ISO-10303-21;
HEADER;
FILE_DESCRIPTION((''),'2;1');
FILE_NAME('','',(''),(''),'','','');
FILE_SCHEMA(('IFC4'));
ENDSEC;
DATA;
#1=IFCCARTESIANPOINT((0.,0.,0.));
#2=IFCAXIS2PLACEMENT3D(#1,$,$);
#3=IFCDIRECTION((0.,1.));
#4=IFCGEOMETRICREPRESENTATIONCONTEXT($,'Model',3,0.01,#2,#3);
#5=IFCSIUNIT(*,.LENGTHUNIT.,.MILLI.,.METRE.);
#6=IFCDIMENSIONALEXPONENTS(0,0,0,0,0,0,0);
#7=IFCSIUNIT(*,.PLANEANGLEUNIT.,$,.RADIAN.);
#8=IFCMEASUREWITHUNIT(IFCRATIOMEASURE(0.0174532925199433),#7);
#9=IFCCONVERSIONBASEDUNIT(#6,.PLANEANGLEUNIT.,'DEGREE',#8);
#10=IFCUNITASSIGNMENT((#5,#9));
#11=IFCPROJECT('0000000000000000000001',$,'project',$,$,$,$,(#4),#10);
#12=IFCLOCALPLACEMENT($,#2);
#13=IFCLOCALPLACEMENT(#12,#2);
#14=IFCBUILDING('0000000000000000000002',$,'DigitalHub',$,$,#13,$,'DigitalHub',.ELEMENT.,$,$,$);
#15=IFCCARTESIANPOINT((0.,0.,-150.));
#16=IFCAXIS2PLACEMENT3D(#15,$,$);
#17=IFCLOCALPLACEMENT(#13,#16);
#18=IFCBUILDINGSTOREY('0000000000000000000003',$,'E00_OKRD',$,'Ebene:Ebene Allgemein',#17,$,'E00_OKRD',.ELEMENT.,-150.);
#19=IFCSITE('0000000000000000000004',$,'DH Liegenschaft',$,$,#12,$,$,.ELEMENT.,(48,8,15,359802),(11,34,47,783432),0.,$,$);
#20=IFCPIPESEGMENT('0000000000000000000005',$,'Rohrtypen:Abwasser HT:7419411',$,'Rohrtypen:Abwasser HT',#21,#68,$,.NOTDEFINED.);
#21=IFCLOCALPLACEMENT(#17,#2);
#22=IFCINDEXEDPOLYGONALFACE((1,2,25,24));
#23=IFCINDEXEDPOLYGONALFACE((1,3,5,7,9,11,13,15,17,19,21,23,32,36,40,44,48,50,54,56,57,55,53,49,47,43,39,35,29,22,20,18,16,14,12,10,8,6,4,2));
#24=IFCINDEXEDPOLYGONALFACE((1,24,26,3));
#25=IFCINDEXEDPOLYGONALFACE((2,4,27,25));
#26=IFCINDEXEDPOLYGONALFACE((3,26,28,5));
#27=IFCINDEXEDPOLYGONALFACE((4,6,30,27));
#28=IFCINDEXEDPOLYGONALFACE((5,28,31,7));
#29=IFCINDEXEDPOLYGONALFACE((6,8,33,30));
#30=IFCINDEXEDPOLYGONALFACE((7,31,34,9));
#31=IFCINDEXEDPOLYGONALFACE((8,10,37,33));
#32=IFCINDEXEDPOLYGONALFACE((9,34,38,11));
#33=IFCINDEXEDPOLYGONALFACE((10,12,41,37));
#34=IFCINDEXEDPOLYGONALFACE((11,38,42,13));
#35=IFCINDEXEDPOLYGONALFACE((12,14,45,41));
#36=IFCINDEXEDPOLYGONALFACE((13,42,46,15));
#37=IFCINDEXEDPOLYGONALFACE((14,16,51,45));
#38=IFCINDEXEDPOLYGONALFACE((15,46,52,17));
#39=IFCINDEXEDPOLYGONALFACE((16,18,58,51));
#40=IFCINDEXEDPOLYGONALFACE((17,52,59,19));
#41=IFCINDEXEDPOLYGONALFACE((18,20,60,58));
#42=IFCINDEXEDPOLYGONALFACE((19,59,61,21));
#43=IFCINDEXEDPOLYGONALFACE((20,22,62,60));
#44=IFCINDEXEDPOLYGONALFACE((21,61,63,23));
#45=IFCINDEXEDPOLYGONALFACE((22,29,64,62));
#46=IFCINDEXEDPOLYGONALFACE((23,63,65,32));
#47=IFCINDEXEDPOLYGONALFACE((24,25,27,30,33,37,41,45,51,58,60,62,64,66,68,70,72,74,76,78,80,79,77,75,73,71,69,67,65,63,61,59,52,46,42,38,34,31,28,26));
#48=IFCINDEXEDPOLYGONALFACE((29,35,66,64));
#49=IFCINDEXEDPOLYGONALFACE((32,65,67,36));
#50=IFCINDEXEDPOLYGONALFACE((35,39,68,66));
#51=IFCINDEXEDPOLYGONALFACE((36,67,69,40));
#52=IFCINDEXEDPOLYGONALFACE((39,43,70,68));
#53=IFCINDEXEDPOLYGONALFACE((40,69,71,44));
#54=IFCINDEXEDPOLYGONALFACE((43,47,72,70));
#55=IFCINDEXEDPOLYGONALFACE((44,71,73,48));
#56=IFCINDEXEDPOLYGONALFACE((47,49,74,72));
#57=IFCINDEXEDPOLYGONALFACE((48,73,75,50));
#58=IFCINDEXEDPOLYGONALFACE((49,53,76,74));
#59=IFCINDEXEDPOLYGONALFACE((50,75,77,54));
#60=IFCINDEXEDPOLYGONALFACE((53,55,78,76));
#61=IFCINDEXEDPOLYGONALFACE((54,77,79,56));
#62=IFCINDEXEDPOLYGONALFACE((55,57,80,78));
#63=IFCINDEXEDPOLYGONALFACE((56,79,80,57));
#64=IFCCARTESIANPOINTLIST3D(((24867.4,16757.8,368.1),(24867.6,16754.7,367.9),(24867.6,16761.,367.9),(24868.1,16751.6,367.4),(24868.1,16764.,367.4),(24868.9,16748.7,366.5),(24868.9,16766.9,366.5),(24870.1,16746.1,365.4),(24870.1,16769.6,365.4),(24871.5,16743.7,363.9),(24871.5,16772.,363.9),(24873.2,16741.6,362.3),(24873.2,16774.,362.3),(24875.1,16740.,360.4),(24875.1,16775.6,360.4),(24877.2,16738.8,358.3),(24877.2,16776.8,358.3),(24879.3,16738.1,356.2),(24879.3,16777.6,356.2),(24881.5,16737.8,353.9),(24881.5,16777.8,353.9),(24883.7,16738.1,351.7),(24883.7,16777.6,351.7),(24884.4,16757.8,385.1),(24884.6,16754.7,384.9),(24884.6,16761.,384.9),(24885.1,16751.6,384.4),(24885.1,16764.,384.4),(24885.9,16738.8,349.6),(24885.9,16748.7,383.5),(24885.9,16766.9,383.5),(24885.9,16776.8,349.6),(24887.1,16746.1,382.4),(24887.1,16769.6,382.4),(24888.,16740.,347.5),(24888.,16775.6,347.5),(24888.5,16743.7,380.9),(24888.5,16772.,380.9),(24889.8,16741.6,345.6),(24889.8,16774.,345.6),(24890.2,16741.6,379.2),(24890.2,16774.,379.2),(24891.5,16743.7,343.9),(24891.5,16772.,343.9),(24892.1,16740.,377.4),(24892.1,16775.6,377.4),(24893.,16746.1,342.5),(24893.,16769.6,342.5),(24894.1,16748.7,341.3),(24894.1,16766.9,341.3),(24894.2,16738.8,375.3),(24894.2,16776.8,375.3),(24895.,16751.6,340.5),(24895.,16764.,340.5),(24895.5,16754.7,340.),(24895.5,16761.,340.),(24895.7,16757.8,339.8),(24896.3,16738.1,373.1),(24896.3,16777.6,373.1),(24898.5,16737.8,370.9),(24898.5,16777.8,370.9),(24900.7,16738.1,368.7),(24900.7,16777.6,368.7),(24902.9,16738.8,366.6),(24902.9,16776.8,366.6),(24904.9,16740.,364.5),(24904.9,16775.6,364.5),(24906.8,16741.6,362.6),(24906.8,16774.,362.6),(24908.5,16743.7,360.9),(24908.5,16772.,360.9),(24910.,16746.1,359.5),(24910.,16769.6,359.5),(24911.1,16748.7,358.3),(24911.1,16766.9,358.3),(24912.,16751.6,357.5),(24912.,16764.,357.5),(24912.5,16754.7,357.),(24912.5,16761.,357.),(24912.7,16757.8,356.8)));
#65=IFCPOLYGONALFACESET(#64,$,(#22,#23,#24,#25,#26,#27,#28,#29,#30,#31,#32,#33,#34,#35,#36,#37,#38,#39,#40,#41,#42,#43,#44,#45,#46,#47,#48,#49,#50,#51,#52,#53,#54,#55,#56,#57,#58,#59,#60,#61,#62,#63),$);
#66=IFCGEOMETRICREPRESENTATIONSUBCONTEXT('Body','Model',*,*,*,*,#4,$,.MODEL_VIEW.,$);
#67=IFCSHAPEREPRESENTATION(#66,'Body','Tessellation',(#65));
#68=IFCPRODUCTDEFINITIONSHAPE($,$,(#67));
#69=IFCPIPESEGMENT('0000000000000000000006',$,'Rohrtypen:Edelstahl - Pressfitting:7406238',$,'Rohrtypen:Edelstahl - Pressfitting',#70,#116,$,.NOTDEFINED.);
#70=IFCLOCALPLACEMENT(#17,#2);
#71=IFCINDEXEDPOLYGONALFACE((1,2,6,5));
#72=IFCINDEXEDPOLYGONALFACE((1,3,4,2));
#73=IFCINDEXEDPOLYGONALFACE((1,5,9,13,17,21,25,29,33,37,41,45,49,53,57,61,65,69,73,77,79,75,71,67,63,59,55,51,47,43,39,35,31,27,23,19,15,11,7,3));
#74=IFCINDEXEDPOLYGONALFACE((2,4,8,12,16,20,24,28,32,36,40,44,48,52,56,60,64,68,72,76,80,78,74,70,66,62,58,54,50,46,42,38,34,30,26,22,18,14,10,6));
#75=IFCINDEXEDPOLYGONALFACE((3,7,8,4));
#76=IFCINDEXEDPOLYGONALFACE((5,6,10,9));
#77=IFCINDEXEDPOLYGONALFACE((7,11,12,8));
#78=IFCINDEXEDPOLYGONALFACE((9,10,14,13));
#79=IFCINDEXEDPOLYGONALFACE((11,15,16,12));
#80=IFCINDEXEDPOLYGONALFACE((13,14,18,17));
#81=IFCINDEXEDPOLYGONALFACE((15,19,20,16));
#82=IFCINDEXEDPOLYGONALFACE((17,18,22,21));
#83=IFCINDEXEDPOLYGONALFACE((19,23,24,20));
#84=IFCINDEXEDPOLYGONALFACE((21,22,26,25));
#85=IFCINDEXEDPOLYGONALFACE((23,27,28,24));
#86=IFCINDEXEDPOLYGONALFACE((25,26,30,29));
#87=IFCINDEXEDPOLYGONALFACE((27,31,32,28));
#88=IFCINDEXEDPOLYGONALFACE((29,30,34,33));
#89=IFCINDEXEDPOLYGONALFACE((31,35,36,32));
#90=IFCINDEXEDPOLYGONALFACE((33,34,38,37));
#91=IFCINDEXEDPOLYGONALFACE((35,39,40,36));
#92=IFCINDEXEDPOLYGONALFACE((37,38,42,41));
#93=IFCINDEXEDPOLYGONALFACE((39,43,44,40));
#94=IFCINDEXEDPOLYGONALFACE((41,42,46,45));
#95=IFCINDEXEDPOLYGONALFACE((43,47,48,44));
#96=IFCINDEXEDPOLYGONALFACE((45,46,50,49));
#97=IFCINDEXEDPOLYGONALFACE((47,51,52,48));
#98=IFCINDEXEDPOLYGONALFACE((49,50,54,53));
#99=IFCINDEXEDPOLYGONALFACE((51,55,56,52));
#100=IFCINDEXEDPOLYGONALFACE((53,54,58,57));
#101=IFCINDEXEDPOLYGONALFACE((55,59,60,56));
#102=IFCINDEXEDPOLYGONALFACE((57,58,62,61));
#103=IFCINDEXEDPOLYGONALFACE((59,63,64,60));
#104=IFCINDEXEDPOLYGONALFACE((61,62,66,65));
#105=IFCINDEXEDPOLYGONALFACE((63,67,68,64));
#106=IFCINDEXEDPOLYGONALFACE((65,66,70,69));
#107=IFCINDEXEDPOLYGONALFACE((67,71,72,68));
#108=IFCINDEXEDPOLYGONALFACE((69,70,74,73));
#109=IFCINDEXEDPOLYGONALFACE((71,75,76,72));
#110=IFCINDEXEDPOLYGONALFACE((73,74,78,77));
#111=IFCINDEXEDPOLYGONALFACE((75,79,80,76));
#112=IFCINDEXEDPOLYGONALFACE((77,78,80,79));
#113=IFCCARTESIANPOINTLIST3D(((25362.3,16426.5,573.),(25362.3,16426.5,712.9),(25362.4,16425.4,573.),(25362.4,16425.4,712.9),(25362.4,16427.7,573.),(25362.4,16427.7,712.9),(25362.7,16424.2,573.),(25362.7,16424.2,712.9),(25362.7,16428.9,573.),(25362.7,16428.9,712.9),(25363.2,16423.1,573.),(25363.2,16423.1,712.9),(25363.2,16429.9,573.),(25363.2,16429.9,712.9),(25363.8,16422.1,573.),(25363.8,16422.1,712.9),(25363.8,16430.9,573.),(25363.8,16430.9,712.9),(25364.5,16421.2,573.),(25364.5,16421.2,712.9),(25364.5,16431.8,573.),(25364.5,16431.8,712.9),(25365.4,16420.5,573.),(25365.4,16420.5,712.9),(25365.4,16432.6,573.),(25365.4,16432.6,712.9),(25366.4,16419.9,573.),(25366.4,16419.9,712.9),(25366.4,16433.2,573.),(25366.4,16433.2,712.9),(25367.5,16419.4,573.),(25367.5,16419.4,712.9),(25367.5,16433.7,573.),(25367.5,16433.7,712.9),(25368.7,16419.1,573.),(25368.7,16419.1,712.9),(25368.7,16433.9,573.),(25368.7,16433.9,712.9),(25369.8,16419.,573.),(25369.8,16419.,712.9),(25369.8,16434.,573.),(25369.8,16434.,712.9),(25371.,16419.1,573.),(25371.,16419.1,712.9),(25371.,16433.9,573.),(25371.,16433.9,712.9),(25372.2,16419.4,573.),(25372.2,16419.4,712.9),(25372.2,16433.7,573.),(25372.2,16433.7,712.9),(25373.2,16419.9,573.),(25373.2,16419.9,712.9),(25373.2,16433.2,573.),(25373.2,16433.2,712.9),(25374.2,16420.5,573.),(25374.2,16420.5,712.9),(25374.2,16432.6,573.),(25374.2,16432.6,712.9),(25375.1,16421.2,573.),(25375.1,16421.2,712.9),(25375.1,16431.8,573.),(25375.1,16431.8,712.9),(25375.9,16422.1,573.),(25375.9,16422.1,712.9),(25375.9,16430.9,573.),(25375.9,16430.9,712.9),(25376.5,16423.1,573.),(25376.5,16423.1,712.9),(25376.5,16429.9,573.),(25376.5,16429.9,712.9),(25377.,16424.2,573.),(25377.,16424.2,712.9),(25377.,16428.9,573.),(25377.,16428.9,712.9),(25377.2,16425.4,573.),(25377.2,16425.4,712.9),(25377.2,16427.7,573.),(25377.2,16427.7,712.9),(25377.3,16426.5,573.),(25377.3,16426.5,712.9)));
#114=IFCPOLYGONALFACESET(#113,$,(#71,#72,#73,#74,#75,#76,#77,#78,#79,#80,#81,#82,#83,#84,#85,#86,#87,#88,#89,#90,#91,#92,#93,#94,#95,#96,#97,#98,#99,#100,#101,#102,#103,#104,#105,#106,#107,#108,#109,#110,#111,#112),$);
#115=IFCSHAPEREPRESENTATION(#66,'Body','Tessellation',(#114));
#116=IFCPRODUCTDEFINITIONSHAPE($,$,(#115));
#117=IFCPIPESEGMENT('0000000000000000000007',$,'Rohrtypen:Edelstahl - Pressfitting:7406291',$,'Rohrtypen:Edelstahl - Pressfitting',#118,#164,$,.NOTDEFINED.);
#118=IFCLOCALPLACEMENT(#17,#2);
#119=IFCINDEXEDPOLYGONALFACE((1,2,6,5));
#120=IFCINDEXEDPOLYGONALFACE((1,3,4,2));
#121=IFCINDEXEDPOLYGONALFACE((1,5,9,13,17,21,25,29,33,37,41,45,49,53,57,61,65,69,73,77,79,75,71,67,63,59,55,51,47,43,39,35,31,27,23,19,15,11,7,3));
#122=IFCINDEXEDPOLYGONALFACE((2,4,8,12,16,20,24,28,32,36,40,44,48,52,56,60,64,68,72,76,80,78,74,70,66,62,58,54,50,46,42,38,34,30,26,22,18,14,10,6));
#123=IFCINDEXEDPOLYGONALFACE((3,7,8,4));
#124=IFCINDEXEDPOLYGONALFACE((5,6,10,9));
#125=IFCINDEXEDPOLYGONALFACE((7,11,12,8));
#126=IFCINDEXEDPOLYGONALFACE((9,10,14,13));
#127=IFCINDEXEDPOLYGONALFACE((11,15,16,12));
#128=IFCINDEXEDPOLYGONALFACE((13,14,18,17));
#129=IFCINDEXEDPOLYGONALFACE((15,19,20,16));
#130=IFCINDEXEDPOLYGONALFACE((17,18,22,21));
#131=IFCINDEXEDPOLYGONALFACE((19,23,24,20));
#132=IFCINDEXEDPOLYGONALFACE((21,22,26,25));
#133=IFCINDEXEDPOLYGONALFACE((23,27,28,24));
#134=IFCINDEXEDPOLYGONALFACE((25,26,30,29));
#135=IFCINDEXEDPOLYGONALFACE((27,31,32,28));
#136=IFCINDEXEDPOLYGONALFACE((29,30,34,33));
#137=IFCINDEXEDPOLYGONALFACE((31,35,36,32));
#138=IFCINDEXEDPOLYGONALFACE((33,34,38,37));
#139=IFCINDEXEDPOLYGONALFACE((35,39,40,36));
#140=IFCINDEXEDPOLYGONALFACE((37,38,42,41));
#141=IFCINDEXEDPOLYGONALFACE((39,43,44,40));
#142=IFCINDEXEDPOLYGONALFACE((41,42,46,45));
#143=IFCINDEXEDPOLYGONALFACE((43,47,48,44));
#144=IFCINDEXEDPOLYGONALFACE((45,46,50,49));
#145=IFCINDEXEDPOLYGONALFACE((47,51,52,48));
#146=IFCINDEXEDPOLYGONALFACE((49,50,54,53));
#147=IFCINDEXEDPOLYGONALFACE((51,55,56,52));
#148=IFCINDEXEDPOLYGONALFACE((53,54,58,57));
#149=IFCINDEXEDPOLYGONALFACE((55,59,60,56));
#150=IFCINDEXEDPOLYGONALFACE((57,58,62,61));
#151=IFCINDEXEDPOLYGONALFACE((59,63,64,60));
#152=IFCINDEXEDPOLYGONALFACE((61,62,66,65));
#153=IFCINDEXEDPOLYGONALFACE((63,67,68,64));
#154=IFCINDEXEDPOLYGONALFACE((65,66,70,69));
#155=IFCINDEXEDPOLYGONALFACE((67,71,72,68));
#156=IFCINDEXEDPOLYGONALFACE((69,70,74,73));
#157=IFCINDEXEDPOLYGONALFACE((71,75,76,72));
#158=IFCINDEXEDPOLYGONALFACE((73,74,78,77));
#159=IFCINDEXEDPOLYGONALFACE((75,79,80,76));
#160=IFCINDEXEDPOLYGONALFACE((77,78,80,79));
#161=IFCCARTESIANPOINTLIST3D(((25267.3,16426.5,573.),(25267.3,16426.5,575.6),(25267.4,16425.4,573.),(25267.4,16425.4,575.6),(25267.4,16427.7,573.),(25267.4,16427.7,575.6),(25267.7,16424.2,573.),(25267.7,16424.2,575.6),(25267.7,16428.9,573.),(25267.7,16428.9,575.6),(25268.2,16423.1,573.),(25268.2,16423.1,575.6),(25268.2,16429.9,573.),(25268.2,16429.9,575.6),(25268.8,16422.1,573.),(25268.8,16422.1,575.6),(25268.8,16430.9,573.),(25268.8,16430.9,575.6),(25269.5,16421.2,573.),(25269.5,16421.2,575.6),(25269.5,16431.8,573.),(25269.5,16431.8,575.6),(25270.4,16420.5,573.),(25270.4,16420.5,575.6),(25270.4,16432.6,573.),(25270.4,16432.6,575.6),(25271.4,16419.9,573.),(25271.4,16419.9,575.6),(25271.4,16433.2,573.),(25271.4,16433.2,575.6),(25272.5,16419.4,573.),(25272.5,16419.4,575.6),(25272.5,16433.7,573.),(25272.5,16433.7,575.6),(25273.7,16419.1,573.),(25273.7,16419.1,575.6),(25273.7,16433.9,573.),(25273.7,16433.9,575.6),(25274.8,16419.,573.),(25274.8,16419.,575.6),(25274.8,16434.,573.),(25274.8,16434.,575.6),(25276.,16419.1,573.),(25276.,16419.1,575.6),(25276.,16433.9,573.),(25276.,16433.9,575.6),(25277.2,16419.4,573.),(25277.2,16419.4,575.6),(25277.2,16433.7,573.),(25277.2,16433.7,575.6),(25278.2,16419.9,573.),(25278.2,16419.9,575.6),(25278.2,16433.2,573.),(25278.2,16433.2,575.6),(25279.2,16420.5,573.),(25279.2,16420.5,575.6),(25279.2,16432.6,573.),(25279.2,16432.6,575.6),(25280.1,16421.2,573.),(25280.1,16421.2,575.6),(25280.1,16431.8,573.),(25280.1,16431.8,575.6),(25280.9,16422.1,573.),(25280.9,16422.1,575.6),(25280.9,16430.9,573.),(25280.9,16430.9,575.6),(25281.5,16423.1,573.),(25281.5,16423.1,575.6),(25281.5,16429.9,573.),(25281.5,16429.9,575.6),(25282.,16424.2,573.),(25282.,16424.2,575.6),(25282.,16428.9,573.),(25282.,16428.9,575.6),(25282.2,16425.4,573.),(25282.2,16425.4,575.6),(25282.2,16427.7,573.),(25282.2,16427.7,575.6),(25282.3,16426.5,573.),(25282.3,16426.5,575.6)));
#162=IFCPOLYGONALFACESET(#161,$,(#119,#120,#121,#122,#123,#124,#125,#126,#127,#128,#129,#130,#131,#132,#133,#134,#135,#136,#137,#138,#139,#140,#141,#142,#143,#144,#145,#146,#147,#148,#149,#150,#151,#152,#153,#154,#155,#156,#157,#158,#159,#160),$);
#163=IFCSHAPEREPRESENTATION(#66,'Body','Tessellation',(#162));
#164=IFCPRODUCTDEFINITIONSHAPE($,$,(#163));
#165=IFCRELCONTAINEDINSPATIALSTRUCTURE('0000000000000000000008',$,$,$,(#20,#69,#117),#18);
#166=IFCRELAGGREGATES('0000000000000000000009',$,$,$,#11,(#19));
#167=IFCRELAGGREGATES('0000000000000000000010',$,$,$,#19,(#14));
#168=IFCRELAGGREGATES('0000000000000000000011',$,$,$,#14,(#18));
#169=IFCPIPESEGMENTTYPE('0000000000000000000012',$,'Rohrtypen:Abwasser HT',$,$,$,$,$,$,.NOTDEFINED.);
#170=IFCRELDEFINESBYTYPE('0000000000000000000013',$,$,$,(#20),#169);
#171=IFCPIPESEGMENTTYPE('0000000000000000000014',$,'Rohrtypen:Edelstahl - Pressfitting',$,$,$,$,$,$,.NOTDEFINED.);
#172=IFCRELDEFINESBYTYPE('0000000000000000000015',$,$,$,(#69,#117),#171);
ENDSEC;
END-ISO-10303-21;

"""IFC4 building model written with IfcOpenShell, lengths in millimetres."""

from ifc_helpers import new_model, entity, si_unit, converted_unit, direction, frame, origin, place, context, subcontext, project, spatial, indexed_curve, outline, extrude, type_object, element, save


model = new_model("IFC4")

# Units and contexts
model_context = context("Model", 3, precision=0.01, world=origin(), true_north=direction((0.0, 1.0)))
body_context = subcontext(model_context, "Body", "Model", "MODEL_VIEW")
ifc_project = project(units=[si_unit("LENGTHUNIT", "METRE", prefix="MILLI"), converted_unit("PLANEANGLEUNIT", "DEGREE", entity("IfcRatioMeasure", 0.0174532925199433), si_unit("PLANEANGLEUNIT", "RADIAN"), dimensions=[0, 0, 0, 0, 0, 0, 0])], contexts=[model_context])

# Site, building, storey
site_placement = place(None, origin())
site = spatial("IfcSite", under=ifc_project, at=site_placement, Name="DH Liegenschaft", CompositionType="ELEMENT", RefLatitude=(48, 8, 15, 359802), RefLongitude=(11, 34, 47, 783432), RefElevation=0.0)
building_placement = place(site_placement, origin())
building = spatial("IfcBuilding", under=site, at=building_placement, Name="DigitalHub", LongName="DigitalHub", CompositionType="ELEMENT")
storey_placement = place(building_placement, frame((0.0, 0.0, -150.0)))
storey = spatial("IfcBuildingStorey", under=building, at=storey_placement, Name="E00_OKRD", ObjectType="Ebene:Ebene Allgemein", LongName="E00_OKRD", CompositionType="ELEMENT", Elevation=-150.0)

# Pipe segments
pipe_segment_type_1 = type_object("IfcPipeSegmentType", Name="Rohrtypen:Abwasser HT", PredefinedType="NOTDEFINED")
pipe_segment_1_placement = place(storey_placement, frame((24865.8, 16736.2, 338.2)))
element("IfcPipeSegment", 1, at=pipe_segment_1_placement, inside=storey, type_object=pipe_segment_type_1, Name="Rohrtypen:Abwasser HT:7419411", ObjectType="Rohrtypen:Abwasser HT", PredefinedType="NOTDEFINED", context=body_context, shape_type="SweptSolid", body=[
    extrude(outline(indexed_curve([(20.0, 0.0), (19.8, 3.1), (19.0, 6.2), (17.8, 9.1), (16.2, 11.8), (14.1, 14.1), (11.8, 16.2), (9.1, 17.8), (6.2, 19.0), (3.1, 19.8), (0.0, 20.0), (-3.1, 19.8), (-6.2, 19.0), (-9.1, 17.8), (-11.8, 16.2), (-14.1, 14.1), (-16.2, 11.8), (-17.8, 9.1), (-19.0, 6.2), (-19.8, 3.1), (-20.0, 0.0), (-19.8, -3.1), (-19.0, -6.2), (-17.8, -9.1), (-16.2, -11.8), (-14.1, -14.1), (-11.8, -16.2), (-9.1, -17.8), (-6.2, -19.0), (-3.1, -19.8), (0.0, -20.0), (3.1, -19.8), (6.2, -19.0), (9.1, -17.8), (11.8, -16.2), (14.1, -14.1), (16.2, -11.8), (17.8, -9.1), (19.0, -6.2), (19.8, -3.1), (20.0, 0.0)], self_intersect=False)), frame((15.7, 21.6, 15.7), z_axis=(0.707107, 0.0, 0.707107), x_axis=(0.0, -1.0, 0.0)), (0.0, 0.0, 1.0), 24.0),
])
pipe_segment_type_2 = type_object("IfcPipeSegmentType", Name="Rohrtypen:Edelstahl - Pressfitting", PredefinedType="NOTDEFINED")
pipe_segment_2_placement = place(storey_placement, frame((25360.7, 16417.4, 573.0)))
element("IfcPipeSegment", 2, at=pipe_segment_2_placement, inside=storey, type_object=pipe_segment_type_2, Name="Rohrtypen:Edelstahl - Pressfitting:7406238", ObjectType="Rohrtypen:Edelstahl - Pressfitting", PredefinedType="NOTDEFINED", context=body_context, shape_type="SweptSolid", body=[
    extrude(outline(indexed_curve([(7.5, 0.0), (7.4, 1.2), (7.1, 2.3), (6.7, 3.4), (6.1, 4.4), (5.3, 5.3), (4.4, 6.1), (3.4, 6.7), (2.3, 7.1), (1.2, 7.4), (0.0, 7.5), (-1.2, 7.4), (-2.3, 7.1), (-3.4, 6.7), (-4.4, 6.1), (-5.3, 5.3), (-6.1, 4.4), (-6.7, 3.4), (-7.1, 2.3), (-7.4, 1.2), (-7.5, 0.0), (-7.4, -1.2), (-7.1, -2.3), (-6.7, -3.4), (-6.1, -4.4), (-5.3, -5.3), (-4.4, -6.1), (-3.4, -6.7), (-2.3, -7.1), (-1.2, -7.4), (0.0, -7.5), (1.2, -7.4), (2.3, -7.1), (3.4, -6.7), (4.4, -6.1), (5.3, -5.3), (6.1, -4.4), (6.7, -3.4), (7.1, -2.3), (7.4, -1.2), (7.5, 0.0)], self_intersect=False)), frame((9.1, 9.1, 0.0), z_axis=(0.0, 0.0, 1.0), x_axis=(-1.0, 0.0, 0.0)), (0.0, 0.0, 1.0), 139.9),
])
pipe_segment_3_placement = place(storey_placement, frame((25265.7, 16417.4, 573.0)))
element("IfcPipeSegment", 3, at=pipe_segment_3_placement, inside=storey, type_object=pipe_segment_type_2, Name="Rohrtypen:Edelstahl - Pressfitting:7406291", ObjectType="Rohrtypen:Edelstahl - Pressfitting", PredefinedType="NOTDEFINED", context=body_context, shape_type="SweptSolid", body=[
    extrude(outline(indexed_curve([(7.5, 0.0), (7.4, 1.2), (7.1, 2.3), (6.7, 3.4), (6.1, 4.4), (5.3, 5.3), (4.4, 6.1), (3.4, 6.7), (2.3, 7.1), (1.2, 7.4), (0.0, 7.5), (-1.2, 7.4), (-2.3, 7.1), (-3.4, 6.7), (-4.4, 6.1), (-5.3, 5.3), (-6.1, 4.4), (-6.7, 3.4), (-7.1, 2.3), (-7.4, 1.2), (-7.5, 0.0), (-7.4, -1.2), (-7.1, -2.3), (-6.7, -3.4), (-6.1, -4.4), (-5.3, -5.3), (-4.4, -6.1), (-3.4, -6.7), (-2.3, -7.1), (-1.2, -7.4), (0.0, -7.5), (1.2, -7.4), (2.3, -7.1), (3.4, -6.7), (4.4, -6.1), (5.3, -5.3), (6.1, -4.4), (6.7, -3.4), (7.1, -2.3), (7.4, -1.2), (7.5, 0.0)], self_intersect=False)), frame((9.1, 9.1, 0.0), z_axis=(0.0, 0.0, 1.0), x_axis=(-1.0, 0.0, 0.0)), (0.0, 0.0, 1.0), 2.6),
])

save(model, "model.ifc")
